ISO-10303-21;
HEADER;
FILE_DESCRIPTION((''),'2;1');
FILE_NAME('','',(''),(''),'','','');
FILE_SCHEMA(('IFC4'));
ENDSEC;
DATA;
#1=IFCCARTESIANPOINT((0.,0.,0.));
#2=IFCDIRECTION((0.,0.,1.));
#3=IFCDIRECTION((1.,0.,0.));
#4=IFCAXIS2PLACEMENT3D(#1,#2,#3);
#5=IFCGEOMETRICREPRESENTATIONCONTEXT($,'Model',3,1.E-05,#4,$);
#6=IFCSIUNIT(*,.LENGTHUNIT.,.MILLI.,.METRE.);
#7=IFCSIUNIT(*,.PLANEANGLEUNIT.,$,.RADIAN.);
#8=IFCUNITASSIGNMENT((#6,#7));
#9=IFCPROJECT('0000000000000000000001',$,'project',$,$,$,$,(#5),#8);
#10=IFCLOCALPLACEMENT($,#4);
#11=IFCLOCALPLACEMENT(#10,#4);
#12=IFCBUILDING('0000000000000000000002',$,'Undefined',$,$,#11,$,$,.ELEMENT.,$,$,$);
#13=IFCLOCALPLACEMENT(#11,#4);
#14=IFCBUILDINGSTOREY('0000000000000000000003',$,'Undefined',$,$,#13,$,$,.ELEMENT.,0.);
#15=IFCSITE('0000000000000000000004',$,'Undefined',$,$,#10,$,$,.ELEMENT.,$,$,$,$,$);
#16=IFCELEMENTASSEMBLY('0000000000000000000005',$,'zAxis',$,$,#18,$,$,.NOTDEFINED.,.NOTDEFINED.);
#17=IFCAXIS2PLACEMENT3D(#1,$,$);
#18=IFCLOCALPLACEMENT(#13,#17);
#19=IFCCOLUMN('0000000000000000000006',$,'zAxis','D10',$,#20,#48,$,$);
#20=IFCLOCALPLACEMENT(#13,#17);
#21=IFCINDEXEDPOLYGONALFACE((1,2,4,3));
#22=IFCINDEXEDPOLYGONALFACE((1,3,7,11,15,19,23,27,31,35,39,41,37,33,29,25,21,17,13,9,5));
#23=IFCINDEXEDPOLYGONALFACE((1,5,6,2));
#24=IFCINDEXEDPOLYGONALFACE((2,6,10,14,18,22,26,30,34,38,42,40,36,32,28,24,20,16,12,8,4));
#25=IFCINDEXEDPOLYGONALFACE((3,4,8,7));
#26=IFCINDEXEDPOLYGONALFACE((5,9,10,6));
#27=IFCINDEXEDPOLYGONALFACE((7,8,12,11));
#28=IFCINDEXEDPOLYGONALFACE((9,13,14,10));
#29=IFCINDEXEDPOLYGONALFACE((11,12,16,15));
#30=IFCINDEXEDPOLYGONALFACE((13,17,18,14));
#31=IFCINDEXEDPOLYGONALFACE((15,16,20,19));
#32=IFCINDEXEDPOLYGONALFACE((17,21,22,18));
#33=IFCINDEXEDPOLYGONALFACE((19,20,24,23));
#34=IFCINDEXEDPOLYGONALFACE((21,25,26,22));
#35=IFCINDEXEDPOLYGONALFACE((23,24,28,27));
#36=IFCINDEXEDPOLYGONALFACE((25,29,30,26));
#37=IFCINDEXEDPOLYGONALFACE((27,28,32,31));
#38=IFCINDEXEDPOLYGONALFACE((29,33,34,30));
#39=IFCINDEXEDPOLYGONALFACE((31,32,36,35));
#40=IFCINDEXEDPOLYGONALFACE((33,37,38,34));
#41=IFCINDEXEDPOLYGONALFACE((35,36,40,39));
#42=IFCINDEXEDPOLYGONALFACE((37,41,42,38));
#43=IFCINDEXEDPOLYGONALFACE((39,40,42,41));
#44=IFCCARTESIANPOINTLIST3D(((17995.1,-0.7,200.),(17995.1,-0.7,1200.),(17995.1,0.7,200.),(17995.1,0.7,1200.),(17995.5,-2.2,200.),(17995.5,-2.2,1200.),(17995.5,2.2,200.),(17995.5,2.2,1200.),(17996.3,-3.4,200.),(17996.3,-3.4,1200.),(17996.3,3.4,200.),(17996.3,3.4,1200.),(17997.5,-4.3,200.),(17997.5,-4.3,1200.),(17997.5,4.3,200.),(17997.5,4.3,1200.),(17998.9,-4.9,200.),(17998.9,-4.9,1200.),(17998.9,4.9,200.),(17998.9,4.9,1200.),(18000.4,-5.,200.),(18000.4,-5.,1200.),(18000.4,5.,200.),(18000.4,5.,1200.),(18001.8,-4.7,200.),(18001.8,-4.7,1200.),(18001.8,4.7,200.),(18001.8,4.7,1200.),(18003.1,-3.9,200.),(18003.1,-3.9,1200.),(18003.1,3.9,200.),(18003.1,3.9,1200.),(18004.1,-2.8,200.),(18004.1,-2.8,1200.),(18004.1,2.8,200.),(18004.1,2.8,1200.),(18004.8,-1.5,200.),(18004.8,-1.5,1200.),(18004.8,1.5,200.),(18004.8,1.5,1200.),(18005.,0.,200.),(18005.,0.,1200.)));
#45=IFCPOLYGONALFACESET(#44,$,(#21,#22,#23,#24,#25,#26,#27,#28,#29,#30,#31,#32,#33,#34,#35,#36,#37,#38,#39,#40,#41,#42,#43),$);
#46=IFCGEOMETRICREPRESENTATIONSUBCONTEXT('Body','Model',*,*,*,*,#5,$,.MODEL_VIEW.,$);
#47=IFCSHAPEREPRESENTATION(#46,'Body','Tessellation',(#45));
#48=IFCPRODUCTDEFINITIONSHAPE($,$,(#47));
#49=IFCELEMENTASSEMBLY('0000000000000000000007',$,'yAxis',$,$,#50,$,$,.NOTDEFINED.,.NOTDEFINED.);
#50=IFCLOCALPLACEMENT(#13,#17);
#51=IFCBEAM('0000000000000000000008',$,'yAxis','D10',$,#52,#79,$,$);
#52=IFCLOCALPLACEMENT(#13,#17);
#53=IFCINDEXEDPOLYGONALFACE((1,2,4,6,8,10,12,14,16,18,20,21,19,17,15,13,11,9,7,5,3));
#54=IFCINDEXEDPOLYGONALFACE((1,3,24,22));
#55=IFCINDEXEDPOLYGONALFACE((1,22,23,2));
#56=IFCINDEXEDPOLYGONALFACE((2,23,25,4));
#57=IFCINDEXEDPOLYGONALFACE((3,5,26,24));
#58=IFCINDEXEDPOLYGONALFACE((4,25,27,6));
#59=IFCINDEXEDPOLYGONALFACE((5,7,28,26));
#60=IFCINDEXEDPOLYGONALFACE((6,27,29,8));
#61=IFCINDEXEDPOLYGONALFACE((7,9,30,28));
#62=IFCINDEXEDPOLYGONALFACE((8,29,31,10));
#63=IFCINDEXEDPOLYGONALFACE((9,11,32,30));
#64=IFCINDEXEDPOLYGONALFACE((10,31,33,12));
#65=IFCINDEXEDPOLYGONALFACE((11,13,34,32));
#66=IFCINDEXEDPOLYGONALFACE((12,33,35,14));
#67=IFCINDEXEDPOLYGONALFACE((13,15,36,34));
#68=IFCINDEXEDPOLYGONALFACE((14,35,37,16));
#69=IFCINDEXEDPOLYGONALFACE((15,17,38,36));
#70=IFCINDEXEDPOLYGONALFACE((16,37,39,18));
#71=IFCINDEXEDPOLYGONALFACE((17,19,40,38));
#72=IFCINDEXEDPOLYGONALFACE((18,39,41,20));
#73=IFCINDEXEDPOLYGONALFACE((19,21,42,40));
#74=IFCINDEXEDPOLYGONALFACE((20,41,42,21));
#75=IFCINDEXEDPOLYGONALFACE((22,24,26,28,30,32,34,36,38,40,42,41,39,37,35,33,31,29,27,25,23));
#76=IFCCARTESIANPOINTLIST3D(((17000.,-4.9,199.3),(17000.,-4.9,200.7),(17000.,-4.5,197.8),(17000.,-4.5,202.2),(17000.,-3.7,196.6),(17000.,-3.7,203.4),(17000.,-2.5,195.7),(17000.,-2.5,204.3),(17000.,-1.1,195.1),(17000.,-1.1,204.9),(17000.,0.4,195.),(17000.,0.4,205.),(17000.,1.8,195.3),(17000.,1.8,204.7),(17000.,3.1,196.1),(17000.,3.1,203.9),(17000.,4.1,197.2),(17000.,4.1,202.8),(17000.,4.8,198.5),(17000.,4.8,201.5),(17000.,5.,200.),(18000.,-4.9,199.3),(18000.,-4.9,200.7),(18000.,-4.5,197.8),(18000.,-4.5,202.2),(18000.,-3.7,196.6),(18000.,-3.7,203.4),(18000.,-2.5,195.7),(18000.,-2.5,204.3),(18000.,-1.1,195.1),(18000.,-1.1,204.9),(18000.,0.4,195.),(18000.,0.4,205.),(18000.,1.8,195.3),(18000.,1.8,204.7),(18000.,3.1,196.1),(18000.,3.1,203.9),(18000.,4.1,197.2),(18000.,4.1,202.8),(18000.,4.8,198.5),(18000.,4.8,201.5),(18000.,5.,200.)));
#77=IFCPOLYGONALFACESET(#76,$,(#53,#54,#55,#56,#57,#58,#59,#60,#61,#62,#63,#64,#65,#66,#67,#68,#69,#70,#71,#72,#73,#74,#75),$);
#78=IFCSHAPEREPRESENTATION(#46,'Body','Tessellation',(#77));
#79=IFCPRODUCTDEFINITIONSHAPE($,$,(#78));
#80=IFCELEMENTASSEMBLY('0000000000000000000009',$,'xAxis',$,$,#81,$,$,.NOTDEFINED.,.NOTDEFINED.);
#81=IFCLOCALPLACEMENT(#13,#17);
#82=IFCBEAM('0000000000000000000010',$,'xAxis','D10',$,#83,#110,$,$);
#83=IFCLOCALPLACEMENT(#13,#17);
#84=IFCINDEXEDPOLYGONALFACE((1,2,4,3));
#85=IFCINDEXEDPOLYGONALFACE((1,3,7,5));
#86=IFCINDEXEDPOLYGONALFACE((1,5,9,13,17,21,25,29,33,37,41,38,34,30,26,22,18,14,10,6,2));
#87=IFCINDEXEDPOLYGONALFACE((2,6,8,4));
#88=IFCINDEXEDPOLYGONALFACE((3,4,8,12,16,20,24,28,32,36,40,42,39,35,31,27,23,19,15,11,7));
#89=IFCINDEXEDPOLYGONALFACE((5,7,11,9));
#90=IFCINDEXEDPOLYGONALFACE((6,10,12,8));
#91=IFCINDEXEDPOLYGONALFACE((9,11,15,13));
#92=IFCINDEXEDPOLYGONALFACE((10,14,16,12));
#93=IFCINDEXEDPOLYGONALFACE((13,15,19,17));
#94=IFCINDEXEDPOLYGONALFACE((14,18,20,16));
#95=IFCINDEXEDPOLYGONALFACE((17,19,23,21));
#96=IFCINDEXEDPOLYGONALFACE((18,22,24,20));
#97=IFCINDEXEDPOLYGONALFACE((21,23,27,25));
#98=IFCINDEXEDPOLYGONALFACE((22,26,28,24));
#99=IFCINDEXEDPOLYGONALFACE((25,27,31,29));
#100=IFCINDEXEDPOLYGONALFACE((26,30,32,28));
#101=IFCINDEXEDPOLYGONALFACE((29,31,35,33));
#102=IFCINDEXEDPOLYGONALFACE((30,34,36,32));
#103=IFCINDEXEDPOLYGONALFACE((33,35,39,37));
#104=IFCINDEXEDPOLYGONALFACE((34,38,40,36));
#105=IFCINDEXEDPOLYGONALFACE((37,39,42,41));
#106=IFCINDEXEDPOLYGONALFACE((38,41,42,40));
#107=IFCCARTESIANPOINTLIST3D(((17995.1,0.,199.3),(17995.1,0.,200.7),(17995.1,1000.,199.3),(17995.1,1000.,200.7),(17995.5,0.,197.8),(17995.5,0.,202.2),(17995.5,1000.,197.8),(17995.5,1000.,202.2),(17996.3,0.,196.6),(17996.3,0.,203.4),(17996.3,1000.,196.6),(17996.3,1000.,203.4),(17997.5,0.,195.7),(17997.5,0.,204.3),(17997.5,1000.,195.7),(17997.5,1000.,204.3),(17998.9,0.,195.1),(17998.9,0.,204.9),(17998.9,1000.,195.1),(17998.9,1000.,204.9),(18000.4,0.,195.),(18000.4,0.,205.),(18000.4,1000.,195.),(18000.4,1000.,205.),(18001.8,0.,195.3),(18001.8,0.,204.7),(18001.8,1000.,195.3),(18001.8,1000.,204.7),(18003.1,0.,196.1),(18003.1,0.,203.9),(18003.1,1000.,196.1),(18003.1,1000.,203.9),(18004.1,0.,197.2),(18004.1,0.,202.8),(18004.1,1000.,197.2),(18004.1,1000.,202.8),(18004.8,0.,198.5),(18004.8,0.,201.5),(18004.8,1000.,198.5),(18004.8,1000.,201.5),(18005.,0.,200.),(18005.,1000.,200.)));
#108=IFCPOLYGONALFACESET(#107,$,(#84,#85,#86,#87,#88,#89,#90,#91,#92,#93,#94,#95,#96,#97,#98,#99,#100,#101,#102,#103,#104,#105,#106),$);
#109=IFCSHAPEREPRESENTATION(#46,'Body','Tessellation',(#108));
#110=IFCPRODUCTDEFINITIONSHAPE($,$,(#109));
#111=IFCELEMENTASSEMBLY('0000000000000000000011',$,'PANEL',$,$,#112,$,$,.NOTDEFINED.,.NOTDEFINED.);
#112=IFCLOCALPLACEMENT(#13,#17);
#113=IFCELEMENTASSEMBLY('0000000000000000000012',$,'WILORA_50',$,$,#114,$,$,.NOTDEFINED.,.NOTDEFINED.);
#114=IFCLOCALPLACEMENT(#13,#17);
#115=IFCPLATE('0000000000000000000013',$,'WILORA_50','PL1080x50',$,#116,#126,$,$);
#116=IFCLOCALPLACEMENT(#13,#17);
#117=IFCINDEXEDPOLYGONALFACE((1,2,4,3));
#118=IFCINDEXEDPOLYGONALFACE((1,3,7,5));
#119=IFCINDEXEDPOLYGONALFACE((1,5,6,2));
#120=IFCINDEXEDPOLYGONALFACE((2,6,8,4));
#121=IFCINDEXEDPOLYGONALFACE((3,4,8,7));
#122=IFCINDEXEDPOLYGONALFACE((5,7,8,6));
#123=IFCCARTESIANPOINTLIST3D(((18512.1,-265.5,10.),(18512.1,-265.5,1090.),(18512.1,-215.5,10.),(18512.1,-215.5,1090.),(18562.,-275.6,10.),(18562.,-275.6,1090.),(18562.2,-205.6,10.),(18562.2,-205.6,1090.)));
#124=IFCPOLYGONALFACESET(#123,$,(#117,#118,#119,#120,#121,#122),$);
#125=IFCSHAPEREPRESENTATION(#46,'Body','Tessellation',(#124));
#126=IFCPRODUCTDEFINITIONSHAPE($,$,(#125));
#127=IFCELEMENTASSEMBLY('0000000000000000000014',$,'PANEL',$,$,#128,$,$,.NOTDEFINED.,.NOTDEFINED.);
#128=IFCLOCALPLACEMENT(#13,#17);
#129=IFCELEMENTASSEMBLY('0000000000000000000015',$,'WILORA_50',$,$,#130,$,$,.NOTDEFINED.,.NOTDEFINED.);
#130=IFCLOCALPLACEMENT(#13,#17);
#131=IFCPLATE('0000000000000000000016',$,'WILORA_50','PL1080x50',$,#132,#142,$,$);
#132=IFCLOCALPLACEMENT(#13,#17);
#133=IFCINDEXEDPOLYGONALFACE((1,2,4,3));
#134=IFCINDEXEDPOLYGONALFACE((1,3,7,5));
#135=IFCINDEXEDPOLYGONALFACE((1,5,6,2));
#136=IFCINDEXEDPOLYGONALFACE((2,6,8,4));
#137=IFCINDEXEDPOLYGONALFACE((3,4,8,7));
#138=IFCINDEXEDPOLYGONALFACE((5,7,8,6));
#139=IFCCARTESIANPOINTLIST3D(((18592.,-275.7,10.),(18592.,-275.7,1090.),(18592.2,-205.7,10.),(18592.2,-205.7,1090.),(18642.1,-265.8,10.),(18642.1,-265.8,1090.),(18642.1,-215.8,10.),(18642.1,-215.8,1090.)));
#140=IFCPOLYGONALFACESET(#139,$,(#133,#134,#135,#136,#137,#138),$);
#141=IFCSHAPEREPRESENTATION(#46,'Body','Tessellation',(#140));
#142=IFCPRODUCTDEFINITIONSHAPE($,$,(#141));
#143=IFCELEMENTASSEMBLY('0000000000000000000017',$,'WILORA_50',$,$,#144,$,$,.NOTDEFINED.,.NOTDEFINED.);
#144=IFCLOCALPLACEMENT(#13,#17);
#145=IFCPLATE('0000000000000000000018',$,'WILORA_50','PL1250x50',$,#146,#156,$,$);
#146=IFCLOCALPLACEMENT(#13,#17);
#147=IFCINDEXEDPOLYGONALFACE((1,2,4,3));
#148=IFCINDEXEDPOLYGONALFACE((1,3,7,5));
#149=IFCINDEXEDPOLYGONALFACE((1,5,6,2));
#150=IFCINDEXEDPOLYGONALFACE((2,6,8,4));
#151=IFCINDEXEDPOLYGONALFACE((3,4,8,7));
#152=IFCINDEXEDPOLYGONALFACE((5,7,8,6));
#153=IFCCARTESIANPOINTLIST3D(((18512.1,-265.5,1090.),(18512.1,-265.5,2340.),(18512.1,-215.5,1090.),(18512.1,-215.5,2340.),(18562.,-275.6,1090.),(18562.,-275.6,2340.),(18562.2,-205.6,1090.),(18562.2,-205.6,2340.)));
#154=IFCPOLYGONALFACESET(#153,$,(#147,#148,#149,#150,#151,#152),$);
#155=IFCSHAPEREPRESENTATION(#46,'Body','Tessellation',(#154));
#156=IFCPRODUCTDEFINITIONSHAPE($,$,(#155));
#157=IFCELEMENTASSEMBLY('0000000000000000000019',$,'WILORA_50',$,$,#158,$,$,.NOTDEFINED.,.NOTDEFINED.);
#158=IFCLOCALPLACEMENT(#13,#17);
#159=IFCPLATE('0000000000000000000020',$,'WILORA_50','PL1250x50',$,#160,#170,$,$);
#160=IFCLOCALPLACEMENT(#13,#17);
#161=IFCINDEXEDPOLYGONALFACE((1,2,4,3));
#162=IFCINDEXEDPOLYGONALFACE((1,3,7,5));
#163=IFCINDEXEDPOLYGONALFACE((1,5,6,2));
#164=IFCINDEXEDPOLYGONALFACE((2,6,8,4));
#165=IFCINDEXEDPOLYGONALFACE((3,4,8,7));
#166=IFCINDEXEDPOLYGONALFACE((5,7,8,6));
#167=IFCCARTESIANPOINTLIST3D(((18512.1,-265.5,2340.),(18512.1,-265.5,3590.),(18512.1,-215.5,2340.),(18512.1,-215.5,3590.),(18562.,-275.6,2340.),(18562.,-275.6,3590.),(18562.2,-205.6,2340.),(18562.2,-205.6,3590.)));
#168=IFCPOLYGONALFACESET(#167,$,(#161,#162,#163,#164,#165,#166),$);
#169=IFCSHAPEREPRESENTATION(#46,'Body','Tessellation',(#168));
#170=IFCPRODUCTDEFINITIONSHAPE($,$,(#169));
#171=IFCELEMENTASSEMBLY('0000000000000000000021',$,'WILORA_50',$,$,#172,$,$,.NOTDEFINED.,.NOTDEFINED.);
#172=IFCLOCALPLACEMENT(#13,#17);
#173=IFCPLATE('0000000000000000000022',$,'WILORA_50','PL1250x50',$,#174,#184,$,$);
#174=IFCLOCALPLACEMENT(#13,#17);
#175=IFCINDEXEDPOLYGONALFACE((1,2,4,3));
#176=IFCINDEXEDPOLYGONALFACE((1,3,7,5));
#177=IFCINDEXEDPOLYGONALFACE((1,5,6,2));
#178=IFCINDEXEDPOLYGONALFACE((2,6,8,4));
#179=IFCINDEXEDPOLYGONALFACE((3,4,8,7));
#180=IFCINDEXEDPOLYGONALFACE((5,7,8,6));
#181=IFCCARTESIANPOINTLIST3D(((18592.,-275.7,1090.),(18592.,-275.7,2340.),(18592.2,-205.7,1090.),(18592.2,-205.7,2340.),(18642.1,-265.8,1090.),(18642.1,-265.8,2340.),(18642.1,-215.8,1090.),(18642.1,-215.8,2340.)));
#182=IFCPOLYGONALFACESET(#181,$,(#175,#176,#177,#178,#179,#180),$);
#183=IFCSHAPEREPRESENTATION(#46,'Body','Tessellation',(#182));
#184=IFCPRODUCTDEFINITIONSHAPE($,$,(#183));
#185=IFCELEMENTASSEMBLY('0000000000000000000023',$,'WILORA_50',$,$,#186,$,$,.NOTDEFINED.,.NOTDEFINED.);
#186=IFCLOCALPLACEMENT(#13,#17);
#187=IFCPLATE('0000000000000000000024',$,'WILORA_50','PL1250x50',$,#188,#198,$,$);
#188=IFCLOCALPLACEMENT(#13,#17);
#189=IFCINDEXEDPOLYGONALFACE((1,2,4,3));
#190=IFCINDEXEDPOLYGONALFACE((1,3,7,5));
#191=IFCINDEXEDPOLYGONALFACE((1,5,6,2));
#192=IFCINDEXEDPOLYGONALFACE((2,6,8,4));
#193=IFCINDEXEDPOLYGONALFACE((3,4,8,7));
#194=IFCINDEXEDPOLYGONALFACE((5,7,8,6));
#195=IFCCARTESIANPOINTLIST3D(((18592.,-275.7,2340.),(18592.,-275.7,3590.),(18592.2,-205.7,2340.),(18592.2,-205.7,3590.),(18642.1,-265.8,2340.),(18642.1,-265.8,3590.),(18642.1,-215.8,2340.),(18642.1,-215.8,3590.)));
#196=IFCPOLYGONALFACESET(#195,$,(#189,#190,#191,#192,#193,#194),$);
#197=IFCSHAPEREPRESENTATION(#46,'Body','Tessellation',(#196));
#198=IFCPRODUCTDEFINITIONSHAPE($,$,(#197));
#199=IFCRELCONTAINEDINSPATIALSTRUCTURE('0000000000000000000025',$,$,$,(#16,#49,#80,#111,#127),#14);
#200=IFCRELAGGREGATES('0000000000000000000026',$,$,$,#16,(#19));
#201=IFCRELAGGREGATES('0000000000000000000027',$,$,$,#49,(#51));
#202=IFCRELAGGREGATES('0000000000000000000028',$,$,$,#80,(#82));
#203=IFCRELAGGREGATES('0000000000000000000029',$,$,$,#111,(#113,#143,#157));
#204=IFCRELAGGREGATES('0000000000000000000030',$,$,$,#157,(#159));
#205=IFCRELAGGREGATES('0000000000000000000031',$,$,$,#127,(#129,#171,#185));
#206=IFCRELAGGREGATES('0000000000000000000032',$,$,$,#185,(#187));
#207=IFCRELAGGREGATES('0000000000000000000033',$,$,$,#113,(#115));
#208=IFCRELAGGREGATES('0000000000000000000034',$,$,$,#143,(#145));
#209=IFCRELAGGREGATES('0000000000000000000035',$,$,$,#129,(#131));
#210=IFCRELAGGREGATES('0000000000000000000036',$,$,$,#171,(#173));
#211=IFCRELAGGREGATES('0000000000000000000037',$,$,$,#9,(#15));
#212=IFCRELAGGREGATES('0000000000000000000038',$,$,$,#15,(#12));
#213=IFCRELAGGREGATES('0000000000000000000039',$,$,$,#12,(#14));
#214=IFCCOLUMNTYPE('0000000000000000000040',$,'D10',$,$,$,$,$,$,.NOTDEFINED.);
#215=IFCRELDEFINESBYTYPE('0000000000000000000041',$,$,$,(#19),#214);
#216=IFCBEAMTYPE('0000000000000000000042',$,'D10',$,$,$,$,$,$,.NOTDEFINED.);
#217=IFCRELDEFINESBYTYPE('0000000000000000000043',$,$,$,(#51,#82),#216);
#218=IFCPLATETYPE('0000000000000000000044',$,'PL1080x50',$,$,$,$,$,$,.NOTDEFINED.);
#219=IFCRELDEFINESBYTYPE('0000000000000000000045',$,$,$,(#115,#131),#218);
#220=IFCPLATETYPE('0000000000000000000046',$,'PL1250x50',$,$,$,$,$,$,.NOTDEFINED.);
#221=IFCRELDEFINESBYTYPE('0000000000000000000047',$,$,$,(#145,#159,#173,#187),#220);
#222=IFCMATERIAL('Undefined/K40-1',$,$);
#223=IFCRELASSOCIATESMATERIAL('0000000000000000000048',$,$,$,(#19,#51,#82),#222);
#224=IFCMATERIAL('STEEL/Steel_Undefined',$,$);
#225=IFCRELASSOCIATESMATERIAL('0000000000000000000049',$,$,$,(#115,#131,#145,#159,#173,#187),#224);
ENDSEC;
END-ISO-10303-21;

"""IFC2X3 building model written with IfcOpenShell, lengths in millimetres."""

from ifc_helpers import new_model, si_unit, frame, origin_with_axes, origin_2d_with_axis, place, context, subcontext, project, spatial, polyline, circle, outline, extrude, material, type_object, element, aggregate, save


model = new_model("IFC2X3")

# Units and contexts
model_context = context("Model", 3, precision=1e-05, world=origin_with_axes())
body_context = subcontext(model_context, "Body", "Model", "MODEL_VIEW")
ifc_project = project(units=[si_unit("LENGTHUNIT", "METRE", prefix="MILLI"), si_unit("PLANEANGLEUNIT", "RADIAN")], contexts=[model_context])

# Site, building, storey
site_placement = place(None, origin_with_axes())
site = spatial("IfcSite", under=ifc_project, at=site_placement, Name="Undefined", CompositionType="ELEMENT")
building_placement = place(site_placement, origin_with_axes())
building = spatial("IfcBuilding", under=site, at=building_placement, Name="Undefined", CompositionType="ELEMENT")
storey_placement = place(building_placement, origin_with_axes())
storey = spatial("IfcBuildingStorey", under=building, at=storey_placement, Name="Undefined", CompositionType="ELEMENT", Elevation=0.0)

# Element assembly, column
assembly_1_placement = place(storey_placement, origin_with_axes())
assembly_1 = element("IfcElementAssembly", 1, at=assembly_1_placement, inside=storey, Name="zAxis", AssemblyPlace="NOTDEFINED", PredefinedType="NOTDEFINED")
ifc_material_1 = material(Name="Undefined/K40-1")
column_type = type_object("IfcColumnType", Name="D10", PredefinedType="NOTDEFINED")
column_placement = place(assembly_1_placement, frame((18000.0, 0.0, 200.0), z_axis=(0.0, 0.0, 1.0), x_axis=(0.0, -1.0, 0.0)))
column = element("IfcColumn", 2, at=column_placement, type_object=column_type, material=ifc_material_1, Name="zAxis", Description="D10", context=body_context, shape_type="SweptSolid", body=[
    extrude(circle(Radius=5.0, at=origin_2d_with_axis()), frame((0.0, 0.0, 1000.0), z_axis=(0.0, 0.0, -1.0), x_axis=(0.0, 1.0, 0.0)), (0.0, 0.0, 1.0), 1000.0),
])
aggregate(assembly_1, [column])

# Element assemblies, beams
assembly_2_placement = place(storey_placement, origin_with_axes())
assembly_2 = element("IfcElementAssembly", 3, at=assembly_2_placement, inside=storey, Name="yAxis", AssemblyPlace="NOTDEFINED", PredefinedType="NOTDEFINED")
beam_type_1 = type_object("IfcBeamType", Name="D10", PredefinedType="NOTDEFINED")
beam_1_placement = place(assembly_2_placement, frame((18000.0, 0.0, 200.0), z_axis=(0.0, 0.0, 1.0), x_axis=(-1.0, 0.0, 0.0)))
beam_1 = element("IfcBeam", 4, at=beam_1_placement, type_object=beam_type_1, material=ifc_material_1, Name="yAxis", Description="D10", context=body_context, shape_type="SweptSolid", body=[
    extrude(circle(Radius=5.0, at=origin_2d_with_axis()), frame((1000.0, 0.0, 0.0), z_axis=(-1.0, 0.0, 0.0), x_axis=(0.0, -1.0, 0.0)), (0.0, 0.0, 1.0), 1000.0),
])
aggregate(assembly_2, [beam_1])
assembly_3_placement = place(storey_placement, origin_with_axes())
assembly_3 = element("IfcElementAssembly", 5, at=assembly_3_placement, inside=storey, Name="xAxis", AssemblyPlace="NOTDEFINED", PredefinedType="NOTDEFINED")
beam_2_placement = place(assembly_3_placement, frame((18000.0, 0.0, 200.0), z_axis=(0.0, 0.0, 1.0), x_axis=(0.0, 1.0, 0.0)))
beam_2 = element("IfcBeam", 6, at=beam_2_placement, type_object=beam_type_1, material=ifc_material_1, Name="xAxis", Description="D10", context=body_context, shape_type="SweptSolid", body=[
    extrude(circle(Radius=5.0, at=origin_2d_with_axis()), frame((1000.0, 0.0, 0.0), z_axis=(-1.0, 0.0, 0.0), x_axis=(0.0, -1.0, 0.0)), (0.0, 0.0, 1.0), 1000.0),
])
aggregate(assembly_3, [beam_2])

# Element assemblies, plates
assembly_4_placement = place(storey_placement, origin_with_axes())
assembly_4 = element("IfcElementAssembly", 7, at=assembly_4_placement, inside=storey, Name="PANEL", AssemblyPlace="NOTDEFINED", PredefinedType="NOTDEFINED")
assembly_5_placement = place(assembly_4_placement, origin_with_axes())
assembly_5 = element("IfcElementAssembly", 8, at=assembly_5_placement, Name="WILORA_50", AssemblyPlace="NOTDEFINED", PredefinedType="NOTDEFINED")
ifc_material_2 = material(Name="STEEL/Steel_Undefined")
plate_type_1 = type_object("IfcPlateType", Name="PL1080x50", PredefinedType="NOTDEFINED")
plate_1_placement = place(assembly_5_placement, frame((18562.0, -275.6, 550.0), z_axis=(0.0, 0.0, 1.0), x_axis=(0.001684, 0.999999, 0.0)))
plate_1 = element("IfcPlate", 9, at=plate_1_placement, type_object=plate_type_1, material=ifc_material_2, Name="WILORA_50", Description="PL1080x50", context=body_context, shape_type="SweptSolid", body=[
    extrude(outline(polyline([(0.0, 0.0), (70.0, 0.0), (60.0, 50.0), (10.0, 50.0), (0.0, 0.0)])), frame((0.0, 0.0, -540.0), z_axis=(0.0, 0.0, 1.0), x_axis=(1.0, 0.0, 0.0)), (0.0, 0.0, 1.0), 1080.0),
])
assembly_6_placement = place(storey_placement, origin_with_axes())
assembly_6 = element("IfcElementAssembly", 10, at=assembly_6_placement, inside=storey, Name="PANEL", AssemblyPlace="NOTDEFINED", PredefinedType="NOTDEFINED")
assembly_7_placement = place(assembly_6_placement, origin_with_axes())
assembly_7 = element("IfcElementAssembly", 11, at=assembly_7_placement, Name="WILORA_50", AssemblyPlace="NOTDEFINED", PredefinedType="NOTDEFINED")
plate_2_placement = place(assembly_7_placement, frame((18592.2, -205.7, 550.0), z_axis=(0.0, 0.0, 1.0), x_axis=(-0.001684, -0.999999, 0.0)))
plate_2 = element("IfcPlate", 12, at=plate_2_placement, type_object=plate_type_1, material=ifc_material_2, Name="WILORA_50", Description="PL1080x50", context=body_context, shape_type="SweptSolid", body=[
    extrude(outline(polyline([(0.0, 0.0), (70.0, 0.0), (60.0, 50.0), (10.0, 50.0), (0.0, 0.0)])), frame((0.0, 0.0, -540.0), z_axis=(0.0, 0.0, 1.0), x_axis=(1.0, 0.0, 0.0)), (0.0, 0.0, 1.0), 1080.0),
])

# Element assembly, plate
assembly_8_placement = place(assembly_4_placement, origin_with_axes())
assembly_8 = element("IfcElementAssembly", 13, at=assembly_8_placement, Name="WILORA_50", AssemblyPlace="NOTDEFINED", PredefinedType="NOTDEFINED")
plate_type_2 = type_object("IfcPlateType", Name="PL1250x50", PredefinedType="NOTDEFINED")
plate_3_placement = place(assembly_8_placement, frame((18562.0, -275.6, 1715.0), z_axis=(0.0, 0.0, 1.0), x_axis=(0.001684, 0.999999, 0.0)))
plate_3 = element("IfcPlate", 14, at=plate_3_placement, type_object=plate_type_2, material=ifc_material_2, Name="WILORA_50", Description="PL1250x50", context=body_context, shape_type="SweptSolid", body=[
    extrude(outline(polyline([(0.0, 0.0), (70.0, 0.0), (60.0, 50.0), (10.0, 50.0), (0.0, 0.0)])), frame((0.0, 0.0, -625.0), z_axis=(0.0, 0.0, 1.0), x_axis=(1.0, 0.0, 0.0)), (0.0, 0.0, 1.0), 1250.0),
])

# Element assembly
assembly_9_placement = place(assembly_4_placement, origin_with_axes())
assembly_9 = element("IfcElementAssembly", 15, at=assembly_9_placement, Name="WILORA_50", AssemblyPlace="NOTDEFINED", PredefinedType="NOTDEFINED")
aggregate(assembly_4, [assembly_5, assembly_8, assembly_9])

# Plate
plate_4_placement = place(assembly_9_placement, frame((18562.0, -275.6, 2965.0), z_axis=(0.0, 0.0, 1.0), x_axis=(0.001684, 0.999999, 0.0)))
plate_4 = element("IfcPlate", 16, at=plate_4_placement, type_object=plate_type_2, material=ifc_material_2, Name="WILORA_50", Description="PL1250x50", context=body_context, shape_type="SweptSolid", body=[
    extrude(outline(polyline([(0.0, 0.0), (70.0, 0.0), (60.0, 50.0), (10.0, 50.0), (0.0, 0.0)])), frame((0.0, 0.0, -625.0), z_axis=(0.0, 0.0, 1.0), x_axis=(1.0, 0.0, 0.0)), (0.0, 0.0, 1.0), 1250.0),
])
aggregate(assembly_9, [plate_4])

# Element assembly, plate
assembly_10_placement = place(assembly_6_placement, origin_with_axes())
assembly_10 = element("IfcElementAssembly", 17, at=assembly_10_placement, Name="WILORA_50", AssemblyPlace="NOTDEFINED", PredefinedType="NOTDEFINED")
plate_5_placement = place(assembly_10_placement, frame((18592.2, -205.7, 1715.0), z_axis=(0.0, 0.0, 1.0), x_axis=(-0.001684, -0.999999, 0.0)))
plate_5 = element("IfcPlate", 18, at=plate_5_placement, type_object=plate_type_2, material=ifc_material_2, Name="WILORA_50", Description="PL1250x50", context=body_context, shape_type="SweptSolid", body=[
    extrude(outline(polyline([(0.0, 0.0), (70.0, 0.0), (60.0, 50.0), (10.0, 50.0), (0.0, 0.0)])), frame((0.0, 0.0, -625.0), z_axis=(0.0, 0.0, 1.0), x_axis=(1.0, 0.0, 0.0)), (0.0, 0.0, 1.0), 1250.0),
])

# Element assembly
assembly_11_placement = place(assembly_6_placement, origin_with_axes())
assembly_11 = element("IfcElementAssembly", 19, at=assembly_11_placement, Name="WILORA_50", AssemblyPlace="NOTDEFINED", PredefinedType="NOTDEFINED")
aggregate(assembly_6, [assembly_7, assembly_10, assembly_11])

# Plate
plate_6_placement = place(assembly_11_placement, frame((18592.2, -205.7, 2965.0), z_axis=(0.0, 0.0, 1.0), x_axis=(-0.001684, -0.999999, 0.0)))
plate_6 = element("IfcPlate", 20, at=plate_6_placement, type_object=plate_type_2, material=ifc_material_2, Name="WILORA_50", Description="PL1250x50", context=body_context, shape_type="SweptSolid", body=[
    extrude(outline(polyline([(0.0, 0.0), (70.0, 0.0), (60.0, 50.0), (10.0, 50.0), (0.0, 0.0)])), frame((0.0, 0.0, -625.0), z_axis=(0.0, 0.0, 1.0), x_axis=(1.0, 0.0, 0.0)), (0.0, 0.0, 1.0), 1250.0),
])
aggregate(assembly_11, [plate_6])

aggregate(assembly_5, [plate_1])
aggregate(assembly_8, [plate_3])
aggregate(assembly_7, [plate_2])
aggregate(assembly_10, [plate_5])

save(model, "model.ifc")
